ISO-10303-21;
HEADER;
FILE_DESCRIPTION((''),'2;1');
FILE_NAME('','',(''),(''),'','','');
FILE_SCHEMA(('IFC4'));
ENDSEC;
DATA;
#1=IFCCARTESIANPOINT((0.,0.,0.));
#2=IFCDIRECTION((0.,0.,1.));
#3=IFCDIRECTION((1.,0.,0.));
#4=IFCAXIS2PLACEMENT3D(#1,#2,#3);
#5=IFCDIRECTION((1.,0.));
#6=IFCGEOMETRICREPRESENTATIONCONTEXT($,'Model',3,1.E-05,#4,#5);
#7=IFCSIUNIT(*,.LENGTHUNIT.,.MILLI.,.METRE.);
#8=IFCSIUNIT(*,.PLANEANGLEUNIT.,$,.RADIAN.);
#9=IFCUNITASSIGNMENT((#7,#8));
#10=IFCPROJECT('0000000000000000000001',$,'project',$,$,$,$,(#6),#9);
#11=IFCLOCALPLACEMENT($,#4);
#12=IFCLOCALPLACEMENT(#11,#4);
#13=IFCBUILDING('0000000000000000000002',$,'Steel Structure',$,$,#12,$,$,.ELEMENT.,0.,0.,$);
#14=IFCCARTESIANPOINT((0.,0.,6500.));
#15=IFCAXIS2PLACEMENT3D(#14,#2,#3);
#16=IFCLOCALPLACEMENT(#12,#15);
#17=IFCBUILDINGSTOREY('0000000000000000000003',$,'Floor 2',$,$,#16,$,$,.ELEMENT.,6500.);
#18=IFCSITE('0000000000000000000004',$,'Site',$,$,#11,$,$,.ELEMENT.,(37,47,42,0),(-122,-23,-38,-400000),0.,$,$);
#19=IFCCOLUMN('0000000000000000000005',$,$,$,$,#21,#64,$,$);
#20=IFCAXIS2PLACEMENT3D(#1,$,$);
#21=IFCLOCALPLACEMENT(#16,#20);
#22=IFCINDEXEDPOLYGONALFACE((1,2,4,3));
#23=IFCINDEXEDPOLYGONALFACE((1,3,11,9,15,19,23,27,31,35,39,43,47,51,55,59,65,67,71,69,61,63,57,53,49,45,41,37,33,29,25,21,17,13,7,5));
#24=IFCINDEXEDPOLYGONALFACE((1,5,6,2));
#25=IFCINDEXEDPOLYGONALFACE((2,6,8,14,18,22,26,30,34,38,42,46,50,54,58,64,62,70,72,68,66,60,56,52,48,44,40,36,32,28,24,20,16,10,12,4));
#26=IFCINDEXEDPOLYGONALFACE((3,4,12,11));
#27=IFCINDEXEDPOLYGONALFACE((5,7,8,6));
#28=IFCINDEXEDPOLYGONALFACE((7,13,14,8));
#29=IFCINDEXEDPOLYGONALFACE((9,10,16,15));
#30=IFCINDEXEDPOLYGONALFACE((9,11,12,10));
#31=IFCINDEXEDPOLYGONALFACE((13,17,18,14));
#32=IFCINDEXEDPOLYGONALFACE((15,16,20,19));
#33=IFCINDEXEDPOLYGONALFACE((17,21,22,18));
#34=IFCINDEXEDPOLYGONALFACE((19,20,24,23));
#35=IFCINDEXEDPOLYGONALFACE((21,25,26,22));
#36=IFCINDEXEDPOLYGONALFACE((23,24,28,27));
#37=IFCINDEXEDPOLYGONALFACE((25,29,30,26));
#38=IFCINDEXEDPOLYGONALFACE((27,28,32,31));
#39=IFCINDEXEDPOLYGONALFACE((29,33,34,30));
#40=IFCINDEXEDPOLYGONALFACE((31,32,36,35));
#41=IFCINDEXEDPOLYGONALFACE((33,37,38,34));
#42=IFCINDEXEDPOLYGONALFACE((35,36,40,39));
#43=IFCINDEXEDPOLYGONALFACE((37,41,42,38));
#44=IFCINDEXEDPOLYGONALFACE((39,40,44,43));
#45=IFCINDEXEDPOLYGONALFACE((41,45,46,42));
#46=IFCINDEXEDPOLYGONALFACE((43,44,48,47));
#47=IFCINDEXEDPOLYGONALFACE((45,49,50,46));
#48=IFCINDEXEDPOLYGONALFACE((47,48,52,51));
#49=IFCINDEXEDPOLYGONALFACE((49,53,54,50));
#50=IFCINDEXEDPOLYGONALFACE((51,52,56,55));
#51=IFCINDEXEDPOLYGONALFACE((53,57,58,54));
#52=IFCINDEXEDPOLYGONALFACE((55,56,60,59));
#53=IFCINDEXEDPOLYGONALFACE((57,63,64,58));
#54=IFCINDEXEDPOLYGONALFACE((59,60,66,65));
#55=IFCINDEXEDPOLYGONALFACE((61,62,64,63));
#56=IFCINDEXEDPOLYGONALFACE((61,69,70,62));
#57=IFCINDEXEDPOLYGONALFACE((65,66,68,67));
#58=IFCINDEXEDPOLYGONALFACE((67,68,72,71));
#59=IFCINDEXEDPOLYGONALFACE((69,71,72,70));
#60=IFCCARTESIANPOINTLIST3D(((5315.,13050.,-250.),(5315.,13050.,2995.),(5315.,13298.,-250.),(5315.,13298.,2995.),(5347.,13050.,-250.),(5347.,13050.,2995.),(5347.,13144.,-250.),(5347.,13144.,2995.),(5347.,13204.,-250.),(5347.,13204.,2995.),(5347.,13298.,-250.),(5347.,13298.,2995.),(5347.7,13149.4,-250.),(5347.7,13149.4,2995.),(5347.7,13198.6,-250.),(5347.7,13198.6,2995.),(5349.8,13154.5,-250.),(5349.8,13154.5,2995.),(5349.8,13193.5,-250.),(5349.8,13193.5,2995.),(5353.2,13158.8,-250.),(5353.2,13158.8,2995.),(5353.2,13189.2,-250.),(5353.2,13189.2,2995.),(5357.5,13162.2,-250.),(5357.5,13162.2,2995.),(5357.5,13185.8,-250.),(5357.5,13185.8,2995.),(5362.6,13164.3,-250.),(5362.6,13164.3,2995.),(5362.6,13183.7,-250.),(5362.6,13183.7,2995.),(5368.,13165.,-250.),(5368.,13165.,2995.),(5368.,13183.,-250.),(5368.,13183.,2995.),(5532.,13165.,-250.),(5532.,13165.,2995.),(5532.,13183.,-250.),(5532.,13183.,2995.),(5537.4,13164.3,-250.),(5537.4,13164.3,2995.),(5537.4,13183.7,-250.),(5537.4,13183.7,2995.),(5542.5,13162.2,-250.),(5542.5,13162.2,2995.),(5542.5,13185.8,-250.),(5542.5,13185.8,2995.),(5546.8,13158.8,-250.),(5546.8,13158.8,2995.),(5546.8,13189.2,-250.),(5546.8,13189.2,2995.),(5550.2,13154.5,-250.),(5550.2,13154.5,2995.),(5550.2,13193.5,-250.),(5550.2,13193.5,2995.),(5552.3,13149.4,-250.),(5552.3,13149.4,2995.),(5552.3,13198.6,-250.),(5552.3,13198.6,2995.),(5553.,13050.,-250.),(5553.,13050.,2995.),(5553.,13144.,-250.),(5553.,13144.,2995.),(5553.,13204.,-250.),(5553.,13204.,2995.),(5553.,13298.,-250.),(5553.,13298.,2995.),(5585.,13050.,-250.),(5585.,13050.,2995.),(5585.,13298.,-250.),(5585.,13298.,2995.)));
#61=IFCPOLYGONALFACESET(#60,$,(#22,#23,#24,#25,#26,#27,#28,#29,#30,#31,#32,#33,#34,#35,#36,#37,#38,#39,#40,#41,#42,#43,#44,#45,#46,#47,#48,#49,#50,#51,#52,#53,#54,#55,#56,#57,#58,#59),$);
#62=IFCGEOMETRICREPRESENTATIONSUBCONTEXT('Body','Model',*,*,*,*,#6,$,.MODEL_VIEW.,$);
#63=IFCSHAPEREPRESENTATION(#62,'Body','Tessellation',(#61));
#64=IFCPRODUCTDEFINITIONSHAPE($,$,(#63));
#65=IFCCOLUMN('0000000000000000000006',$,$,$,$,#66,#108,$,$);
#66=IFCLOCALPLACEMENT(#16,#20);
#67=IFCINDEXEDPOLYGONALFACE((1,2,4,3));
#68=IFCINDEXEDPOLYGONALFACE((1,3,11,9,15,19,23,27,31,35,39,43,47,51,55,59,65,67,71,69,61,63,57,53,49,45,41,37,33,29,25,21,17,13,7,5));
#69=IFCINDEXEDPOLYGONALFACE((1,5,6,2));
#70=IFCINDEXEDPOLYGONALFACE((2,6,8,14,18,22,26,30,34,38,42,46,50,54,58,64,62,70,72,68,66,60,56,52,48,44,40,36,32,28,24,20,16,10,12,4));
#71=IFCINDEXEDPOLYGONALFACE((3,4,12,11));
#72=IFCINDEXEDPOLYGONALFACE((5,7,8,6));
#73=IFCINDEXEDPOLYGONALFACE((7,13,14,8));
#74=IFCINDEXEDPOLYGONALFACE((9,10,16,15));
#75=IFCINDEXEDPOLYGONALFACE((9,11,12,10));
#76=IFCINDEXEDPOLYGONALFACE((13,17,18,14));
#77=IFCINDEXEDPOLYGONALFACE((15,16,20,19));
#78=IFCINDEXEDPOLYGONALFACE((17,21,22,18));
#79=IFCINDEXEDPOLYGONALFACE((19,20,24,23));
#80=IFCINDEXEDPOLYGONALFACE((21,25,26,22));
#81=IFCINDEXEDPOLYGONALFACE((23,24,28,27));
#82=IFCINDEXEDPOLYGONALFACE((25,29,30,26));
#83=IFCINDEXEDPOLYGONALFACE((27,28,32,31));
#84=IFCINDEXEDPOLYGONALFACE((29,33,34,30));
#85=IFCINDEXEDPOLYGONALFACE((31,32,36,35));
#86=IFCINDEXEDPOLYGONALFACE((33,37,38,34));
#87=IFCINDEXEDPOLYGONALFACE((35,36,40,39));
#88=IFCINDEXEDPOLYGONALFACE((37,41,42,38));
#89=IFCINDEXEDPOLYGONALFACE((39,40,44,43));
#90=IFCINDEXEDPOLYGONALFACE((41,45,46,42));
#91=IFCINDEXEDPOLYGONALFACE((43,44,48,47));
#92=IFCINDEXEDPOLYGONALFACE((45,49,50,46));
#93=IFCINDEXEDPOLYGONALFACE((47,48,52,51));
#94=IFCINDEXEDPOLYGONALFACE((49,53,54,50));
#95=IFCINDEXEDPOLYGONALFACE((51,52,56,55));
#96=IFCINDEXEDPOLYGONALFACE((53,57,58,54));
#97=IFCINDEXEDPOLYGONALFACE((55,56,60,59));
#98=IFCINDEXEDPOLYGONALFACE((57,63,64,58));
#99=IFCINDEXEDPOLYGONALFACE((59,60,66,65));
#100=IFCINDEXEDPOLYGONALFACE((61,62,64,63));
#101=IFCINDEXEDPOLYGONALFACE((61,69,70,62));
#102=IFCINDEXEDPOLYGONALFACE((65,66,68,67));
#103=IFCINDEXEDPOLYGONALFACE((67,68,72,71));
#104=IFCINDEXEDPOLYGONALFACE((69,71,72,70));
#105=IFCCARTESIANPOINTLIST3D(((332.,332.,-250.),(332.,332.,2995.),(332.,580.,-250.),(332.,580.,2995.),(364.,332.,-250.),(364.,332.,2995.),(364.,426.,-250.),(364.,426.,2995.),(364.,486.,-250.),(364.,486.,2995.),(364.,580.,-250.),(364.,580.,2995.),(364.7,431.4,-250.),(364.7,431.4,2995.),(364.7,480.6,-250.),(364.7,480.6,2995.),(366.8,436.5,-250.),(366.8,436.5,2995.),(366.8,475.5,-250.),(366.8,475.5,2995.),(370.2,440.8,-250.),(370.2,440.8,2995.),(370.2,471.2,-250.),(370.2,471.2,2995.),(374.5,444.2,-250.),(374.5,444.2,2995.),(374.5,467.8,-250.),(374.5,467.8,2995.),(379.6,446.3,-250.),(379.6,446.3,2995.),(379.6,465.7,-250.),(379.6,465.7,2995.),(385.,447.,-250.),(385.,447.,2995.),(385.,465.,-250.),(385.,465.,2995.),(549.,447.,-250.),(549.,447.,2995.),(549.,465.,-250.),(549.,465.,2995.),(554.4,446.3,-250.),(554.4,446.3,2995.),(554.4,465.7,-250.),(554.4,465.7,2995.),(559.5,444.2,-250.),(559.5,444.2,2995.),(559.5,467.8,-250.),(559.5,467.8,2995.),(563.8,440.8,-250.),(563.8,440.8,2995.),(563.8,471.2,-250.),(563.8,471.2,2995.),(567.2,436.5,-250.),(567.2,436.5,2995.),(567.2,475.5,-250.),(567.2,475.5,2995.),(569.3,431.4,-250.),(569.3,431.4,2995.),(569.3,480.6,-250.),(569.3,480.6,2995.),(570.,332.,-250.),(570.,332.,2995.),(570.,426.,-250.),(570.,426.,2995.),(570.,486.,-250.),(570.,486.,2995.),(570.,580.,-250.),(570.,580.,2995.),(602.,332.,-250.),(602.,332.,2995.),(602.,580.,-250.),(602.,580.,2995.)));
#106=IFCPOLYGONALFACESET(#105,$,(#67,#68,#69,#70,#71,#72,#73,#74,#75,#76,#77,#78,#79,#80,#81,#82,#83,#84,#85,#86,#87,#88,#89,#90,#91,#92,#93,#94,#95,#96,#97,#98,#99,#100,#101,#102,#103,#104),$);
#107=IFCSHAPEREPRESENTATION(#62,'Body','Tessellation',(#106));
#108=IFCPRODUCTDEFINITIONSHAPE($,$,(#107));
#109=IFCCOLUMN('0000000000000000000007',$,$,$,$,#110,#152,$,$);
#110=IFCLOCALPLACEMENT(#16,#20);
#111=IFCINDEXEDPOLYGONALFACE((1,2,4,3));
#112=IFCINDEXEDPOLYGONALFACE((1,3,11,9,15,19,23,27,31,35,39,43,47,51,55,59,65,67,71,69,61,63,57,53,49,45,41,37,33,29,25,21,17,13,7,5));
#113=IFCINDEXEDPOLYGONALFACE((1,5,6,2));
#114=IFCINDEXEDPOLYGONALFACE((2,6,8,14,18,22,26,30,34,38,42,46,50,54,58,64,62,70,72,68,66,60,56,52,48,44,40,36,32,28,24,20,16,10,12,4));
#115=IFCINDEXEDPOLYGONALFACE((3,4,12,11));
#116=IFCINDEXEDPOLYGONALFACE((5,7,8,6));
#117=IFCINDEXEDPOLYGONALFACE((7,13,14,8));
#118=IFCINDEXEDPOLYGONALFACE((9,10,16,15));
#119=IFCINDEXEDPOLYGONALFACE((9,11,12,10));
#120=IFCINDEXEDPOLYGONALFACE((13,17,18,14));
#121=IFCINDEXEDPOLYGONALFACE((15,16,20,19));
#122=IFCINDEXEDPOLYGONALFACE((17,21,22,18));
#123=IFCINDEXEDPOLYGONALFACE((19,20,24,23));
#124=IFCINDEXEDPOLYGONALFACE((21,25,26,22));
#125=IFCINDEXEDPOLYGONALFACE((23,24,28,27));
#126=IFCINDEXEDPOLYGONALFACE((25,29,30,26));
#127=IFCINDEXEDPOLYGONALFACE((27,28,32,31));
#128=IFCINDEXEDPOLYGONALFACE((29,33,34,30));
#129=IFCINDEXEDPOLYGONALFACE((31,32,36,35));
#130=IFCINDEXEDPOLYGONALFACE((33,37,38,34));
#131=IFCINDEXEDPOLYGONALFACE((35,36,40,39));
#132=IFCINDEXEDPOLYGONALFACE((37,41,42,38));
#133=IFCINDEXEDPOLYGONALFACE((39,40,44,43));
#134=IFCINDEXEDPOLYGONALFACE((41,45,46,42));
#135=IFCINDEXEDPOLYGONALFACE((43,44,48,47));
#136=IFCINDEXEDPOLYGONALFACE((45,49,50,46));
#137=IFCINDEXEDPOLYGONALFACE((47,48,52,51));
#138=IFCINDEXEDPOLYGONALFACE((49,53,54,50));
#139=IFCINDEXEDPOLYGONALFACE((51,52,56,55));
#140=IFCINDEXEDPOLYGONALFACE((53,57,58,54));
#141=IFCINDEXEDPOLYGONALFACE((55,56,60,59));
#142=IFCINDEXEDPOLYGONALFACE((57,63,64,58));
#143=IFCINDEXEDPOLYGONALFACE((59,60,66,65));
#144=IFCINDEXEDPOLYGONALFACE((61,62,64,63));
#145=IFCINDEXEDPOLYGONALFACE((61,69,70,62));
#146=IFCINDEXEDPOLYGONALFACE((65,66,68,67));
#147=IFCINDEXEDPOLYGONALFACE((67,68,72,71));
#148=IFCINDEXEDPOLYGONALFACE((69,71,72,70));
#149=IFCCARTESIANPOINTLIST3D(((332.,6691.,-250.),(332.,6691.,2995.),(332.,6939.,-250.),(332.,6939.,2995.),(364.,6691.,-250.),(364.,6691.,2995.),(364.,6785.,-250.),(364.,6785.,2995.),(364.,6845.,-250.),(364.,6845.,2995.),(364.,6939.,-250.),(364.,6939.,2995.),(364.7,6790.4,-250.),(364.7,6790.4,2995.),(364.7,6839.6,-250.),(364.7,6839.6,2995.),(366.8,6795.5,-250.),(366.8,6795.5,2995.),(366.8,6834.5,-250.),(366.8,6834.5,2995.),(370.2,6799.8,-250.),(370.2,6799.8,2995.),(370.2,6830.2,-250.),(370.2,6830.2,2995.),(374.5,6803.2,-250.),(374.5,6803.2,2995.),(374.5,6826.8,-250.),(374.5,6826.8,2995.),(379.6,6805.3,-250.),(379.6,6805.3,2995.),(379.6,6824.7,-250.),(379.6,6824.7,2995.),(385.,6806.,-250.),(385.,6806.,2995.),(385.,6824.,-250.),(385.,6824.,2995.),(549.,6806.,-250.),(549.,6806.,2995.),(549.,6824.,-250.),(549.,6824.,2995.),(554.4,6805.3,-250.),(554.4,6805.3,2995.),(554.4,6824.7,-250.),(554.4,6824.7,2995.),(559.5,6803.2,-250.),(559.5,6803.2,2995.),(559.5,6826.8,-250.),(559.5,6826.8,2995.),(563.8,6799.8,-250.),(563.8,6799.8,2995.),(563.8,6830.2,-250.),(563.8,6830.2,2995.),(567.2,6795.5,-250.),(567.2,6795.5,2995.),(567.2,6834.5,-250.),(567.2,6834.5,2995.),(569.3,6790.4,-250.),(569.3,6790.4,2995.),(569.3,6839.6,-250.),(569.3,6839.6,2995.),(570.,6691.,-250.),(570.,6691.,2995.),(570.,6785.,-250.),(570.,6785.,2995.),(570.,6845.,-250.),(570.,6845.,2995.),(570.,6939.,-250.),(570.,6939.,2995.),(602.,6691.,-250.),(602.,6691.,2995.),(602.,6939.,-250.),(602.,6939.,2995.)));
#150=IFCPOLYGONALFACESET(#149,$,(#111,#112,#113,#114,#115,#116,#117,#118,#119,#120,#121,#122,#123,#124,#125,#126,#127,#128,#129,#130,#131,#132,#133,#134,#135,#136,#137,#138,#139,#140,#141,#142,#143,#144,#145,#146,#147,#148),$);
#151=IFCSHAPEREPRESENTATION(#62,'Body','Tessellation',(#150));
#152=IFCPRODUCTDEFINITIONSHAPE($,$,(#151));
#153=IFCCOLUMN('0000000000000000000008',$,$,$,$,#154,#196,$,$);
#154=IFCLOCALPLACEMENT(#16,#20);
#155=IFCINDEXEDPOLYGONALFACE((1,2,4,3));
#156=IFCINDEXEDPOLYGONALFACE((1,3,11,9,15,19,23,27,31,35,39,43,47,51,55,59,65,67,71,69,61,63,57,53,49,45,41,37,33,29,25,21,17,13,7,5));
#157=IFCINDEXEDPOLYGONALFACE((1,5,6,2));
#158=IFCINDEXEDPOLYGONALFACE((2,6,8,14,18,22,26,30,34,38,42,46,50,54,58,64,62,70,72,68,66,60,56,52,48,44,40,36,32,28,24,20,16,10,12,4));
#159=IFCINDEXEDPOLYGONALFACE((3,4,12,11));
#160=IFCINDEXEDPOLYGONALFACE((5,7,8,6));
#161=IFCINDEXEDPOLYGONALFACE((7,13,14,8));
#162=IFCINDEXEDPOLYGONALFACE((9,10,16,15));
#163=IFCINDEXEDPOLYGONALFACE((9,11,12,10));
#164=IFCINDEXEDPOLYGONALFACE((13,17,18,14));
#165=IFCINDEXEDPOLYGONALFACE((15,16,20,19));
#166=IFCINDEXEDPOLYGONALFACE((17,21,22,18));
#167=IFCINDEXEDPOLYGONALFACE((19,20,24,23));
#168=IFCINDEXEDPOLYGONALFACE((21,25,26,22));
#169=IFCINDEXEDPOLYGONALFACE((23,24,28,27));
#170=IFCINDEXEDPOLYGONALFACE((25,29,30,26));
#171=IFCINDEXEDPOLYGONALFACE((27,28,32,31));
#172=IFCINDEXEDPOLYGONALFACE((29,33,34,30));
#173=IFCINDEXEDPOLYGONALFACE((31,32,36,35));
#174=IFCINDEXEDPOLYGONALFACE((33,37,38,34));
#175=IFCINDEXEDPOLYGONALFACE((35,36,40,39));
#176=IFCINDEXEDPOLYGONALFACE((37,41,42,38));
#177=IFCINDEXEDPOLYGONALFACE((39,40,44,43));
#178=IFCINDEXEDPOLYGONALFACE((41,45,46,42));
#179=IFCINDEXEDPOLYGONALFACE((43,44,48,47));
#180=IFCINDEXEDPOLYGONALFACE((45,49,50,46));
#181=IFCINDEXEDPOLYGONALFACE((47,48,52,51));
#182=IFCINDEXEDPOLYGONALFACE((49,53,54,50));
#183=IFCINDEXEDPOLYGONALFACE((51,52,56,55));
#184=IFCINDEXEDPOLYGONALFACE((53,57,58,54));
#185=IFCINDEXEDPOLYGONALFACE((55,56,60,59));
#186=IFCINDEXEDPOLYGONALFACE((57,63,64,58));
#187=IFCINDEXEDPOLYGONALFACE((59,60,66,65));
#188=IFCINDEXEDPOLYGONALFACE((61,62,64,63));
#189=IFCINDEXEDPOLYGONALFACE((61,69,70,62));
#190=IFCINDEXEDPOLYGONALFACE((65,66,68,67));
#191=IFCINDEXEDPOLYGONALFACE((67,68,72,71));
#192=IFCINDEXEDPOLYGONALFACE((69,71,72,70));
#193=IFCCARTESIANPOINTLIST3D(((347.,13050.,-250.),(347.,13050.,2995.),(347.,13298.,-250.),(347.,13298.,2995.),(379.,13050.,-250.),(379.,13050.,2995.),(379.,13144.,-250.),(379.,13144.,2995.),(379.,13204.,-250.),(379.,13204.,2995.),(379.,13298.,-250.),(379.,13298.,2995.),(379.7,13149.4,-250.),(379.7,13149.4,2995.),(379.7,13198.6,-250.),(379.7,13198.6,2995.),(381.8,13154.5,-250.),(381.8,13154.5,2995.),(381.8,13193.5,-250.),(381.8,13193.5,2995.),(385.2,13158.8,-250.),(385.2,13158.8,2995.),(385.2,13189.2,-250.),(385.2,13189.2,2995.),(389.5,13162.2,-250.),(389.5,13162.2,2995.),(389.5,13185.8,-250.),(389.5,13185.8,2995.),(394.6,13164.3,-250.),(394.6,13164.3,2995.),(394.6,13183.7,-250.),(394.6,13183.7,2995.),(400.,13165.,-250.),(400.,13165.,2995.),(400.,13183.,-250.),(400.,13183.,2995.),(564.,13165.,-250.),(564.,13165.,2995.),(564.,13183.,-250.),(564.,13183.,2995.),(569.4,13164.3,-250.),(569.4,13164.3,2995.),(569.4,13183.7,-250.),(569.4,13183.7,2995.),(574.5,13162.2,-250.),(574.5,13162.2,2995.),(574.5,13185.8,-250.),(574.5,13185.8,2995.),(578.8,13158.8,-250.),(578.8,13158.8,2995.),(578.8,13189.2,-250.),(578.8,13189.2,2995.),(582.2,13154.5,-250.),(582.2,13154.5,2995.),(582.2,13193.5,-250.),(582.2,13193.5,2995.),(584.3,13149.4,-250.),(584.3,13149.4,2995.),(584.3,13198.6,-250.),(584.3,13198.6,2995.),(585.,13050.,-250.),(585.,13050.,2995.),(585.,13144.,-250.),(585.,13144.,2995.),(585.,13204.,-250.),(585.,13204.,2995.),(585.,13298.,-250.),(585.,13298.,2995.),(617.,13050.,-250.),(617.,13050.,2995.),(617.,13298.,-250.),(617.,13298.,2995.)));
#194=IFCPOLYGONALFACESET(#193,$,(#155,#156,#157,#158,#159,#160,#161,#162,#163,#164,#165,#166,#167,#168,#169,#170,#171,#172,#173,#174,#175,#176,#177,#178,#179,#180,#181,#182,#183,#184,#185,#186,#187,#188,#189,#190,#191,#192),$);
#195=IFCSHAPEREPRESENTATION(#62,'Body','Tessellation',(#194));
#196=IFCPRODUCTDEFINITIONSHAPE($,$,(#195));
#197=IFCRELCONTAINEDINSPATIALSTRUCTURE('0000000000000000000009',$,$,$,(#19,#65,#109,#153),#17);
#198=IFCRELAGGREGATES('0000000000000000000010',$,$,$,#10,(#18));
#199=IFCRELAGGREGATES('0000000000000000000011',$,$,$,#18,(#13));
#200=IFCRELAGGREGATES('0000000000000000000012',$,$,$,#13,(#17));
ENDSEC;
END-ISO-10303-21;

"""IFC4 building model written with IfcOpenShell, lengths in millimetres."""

from ifc_helpers import new_model, si_unit, direction, frame, origin_with_axes, origin_2d_with_axis, place, context, subcontext, project, spatial, i_section, extrude, element, save


model = new_model("IFC4")

# Units and contexts
model_context = context("Model", 3, precision=1e-05, world=origin_with_axes(), true_north=direction((1.0, 0.0)))
body_context = subcontext(model_context, "Body", "Model", "MODEL_VIEW")
ifc_project = project(units=[si_unit("LENGTHUNIT", "METRE", prefix="MILLI"), si_unit("PLANEANGLEUNIT", "RADIAN")], contexts=[model_context])

# Site, building, storey
site_placement = place(None, origin_with_axes())
site = spatial("IfcSite", under=ifc_project, at=site_placement, Name="Site", CompositionType="ELEMENT", RefLatitude=(37, 47, 42, 0), RefLongitude=(-122, -23, -38, -400000), RefElevation=0.0)
building_placement = place(site_placement, origin_with_axes())
building = spatial("IfcBuilding", under=site, at=building_placement, Name="Steel Structure", CompositionType="ELEMENT", ElevationOfRefHeight=0.0, ElevationOfTerrain=0.0)
storey_placement = place(building_placement, frame((0.0, 0.0, 6500.0), z_axis=(0.0, 0.0, 1.0), x_axis=(1.0, 0.0, 0.0)))
storey = spatial("IfcBuildingStorey", under=building, at=storey_placement, Name="Floor 2", CompositionType="ELEMENT", Elevation=6500.0)

# Columns
column_1_placement = place(storey_placement, frame((5450.0, 13174.0, -250.0), z_axis=(0.0, 0.0, 1.0), x_axis=(0.0, -1.0, 0.0)))
element("IfcColumn", 1, at=column_1_placement, inside=storey, context=body_context, shape_type="SweptSolid", body=[
    extrude(i_section(OverallWidth=248.0, OverallDepth=270.0, WebThickness=18.0, FlangeThickness=32.0, FilletRadius=21.0, at=origin_2d_with_axis()), origin_with_axes(), (0.0, 0.0, 1.0), 3245.0),
])
for number, where, z_axis, x_axis in (
    (2, (467.0, 456.0, -250.0), (0.0, 0.0, 1.0), (0.0, 1.0, 0.0)),
    (3, (467.0, 6815.0, -250.0), (0.0, 0.0, 1.0), (0.0, -1.0, 0.0)),
):
    element("IfcColumn", number, at=place(storey_placement, frame(where, z_axis=z_axis, x_axis=x_axis)), inside=storey, context=body_context, shape_type="SweptSolid", body=[
        extrude(i_section(OverallWidth=248.0, OverallDepth=270.0, WebThickness=18.0, FlangeThickness=32.0, FilletRadius=21.0, at=origin_2d_with_axis()), origin_with_axes(), (0.0, 0.0, 1.0), 3245.0),
    ])
for number, where, z_axis, x_axis in (
    (4, (482.0, 13174.0, -250.0), (0.0, 0.0, 1.0), (0.0, -1.0, 0.0)),
):
    element("IfcColumn", number, at=place(storey_placement, frame(where, z_axis=z_axis, x_axis=x_axis)), inside=storey, context=body_context, shape_type="SweptSolid", body=[
        extrude(i_section(OverallWidth=248.0, OverallDepth=270.0, WebThickness=18.0, FlangeThickness=32.0, FilletRadius=21.0, at=origin_2d_with_axis()), origin_with_axes(), (0.0, 0.0, 1.0), 3245.0),
    ])

save(model, "model.ifc")
